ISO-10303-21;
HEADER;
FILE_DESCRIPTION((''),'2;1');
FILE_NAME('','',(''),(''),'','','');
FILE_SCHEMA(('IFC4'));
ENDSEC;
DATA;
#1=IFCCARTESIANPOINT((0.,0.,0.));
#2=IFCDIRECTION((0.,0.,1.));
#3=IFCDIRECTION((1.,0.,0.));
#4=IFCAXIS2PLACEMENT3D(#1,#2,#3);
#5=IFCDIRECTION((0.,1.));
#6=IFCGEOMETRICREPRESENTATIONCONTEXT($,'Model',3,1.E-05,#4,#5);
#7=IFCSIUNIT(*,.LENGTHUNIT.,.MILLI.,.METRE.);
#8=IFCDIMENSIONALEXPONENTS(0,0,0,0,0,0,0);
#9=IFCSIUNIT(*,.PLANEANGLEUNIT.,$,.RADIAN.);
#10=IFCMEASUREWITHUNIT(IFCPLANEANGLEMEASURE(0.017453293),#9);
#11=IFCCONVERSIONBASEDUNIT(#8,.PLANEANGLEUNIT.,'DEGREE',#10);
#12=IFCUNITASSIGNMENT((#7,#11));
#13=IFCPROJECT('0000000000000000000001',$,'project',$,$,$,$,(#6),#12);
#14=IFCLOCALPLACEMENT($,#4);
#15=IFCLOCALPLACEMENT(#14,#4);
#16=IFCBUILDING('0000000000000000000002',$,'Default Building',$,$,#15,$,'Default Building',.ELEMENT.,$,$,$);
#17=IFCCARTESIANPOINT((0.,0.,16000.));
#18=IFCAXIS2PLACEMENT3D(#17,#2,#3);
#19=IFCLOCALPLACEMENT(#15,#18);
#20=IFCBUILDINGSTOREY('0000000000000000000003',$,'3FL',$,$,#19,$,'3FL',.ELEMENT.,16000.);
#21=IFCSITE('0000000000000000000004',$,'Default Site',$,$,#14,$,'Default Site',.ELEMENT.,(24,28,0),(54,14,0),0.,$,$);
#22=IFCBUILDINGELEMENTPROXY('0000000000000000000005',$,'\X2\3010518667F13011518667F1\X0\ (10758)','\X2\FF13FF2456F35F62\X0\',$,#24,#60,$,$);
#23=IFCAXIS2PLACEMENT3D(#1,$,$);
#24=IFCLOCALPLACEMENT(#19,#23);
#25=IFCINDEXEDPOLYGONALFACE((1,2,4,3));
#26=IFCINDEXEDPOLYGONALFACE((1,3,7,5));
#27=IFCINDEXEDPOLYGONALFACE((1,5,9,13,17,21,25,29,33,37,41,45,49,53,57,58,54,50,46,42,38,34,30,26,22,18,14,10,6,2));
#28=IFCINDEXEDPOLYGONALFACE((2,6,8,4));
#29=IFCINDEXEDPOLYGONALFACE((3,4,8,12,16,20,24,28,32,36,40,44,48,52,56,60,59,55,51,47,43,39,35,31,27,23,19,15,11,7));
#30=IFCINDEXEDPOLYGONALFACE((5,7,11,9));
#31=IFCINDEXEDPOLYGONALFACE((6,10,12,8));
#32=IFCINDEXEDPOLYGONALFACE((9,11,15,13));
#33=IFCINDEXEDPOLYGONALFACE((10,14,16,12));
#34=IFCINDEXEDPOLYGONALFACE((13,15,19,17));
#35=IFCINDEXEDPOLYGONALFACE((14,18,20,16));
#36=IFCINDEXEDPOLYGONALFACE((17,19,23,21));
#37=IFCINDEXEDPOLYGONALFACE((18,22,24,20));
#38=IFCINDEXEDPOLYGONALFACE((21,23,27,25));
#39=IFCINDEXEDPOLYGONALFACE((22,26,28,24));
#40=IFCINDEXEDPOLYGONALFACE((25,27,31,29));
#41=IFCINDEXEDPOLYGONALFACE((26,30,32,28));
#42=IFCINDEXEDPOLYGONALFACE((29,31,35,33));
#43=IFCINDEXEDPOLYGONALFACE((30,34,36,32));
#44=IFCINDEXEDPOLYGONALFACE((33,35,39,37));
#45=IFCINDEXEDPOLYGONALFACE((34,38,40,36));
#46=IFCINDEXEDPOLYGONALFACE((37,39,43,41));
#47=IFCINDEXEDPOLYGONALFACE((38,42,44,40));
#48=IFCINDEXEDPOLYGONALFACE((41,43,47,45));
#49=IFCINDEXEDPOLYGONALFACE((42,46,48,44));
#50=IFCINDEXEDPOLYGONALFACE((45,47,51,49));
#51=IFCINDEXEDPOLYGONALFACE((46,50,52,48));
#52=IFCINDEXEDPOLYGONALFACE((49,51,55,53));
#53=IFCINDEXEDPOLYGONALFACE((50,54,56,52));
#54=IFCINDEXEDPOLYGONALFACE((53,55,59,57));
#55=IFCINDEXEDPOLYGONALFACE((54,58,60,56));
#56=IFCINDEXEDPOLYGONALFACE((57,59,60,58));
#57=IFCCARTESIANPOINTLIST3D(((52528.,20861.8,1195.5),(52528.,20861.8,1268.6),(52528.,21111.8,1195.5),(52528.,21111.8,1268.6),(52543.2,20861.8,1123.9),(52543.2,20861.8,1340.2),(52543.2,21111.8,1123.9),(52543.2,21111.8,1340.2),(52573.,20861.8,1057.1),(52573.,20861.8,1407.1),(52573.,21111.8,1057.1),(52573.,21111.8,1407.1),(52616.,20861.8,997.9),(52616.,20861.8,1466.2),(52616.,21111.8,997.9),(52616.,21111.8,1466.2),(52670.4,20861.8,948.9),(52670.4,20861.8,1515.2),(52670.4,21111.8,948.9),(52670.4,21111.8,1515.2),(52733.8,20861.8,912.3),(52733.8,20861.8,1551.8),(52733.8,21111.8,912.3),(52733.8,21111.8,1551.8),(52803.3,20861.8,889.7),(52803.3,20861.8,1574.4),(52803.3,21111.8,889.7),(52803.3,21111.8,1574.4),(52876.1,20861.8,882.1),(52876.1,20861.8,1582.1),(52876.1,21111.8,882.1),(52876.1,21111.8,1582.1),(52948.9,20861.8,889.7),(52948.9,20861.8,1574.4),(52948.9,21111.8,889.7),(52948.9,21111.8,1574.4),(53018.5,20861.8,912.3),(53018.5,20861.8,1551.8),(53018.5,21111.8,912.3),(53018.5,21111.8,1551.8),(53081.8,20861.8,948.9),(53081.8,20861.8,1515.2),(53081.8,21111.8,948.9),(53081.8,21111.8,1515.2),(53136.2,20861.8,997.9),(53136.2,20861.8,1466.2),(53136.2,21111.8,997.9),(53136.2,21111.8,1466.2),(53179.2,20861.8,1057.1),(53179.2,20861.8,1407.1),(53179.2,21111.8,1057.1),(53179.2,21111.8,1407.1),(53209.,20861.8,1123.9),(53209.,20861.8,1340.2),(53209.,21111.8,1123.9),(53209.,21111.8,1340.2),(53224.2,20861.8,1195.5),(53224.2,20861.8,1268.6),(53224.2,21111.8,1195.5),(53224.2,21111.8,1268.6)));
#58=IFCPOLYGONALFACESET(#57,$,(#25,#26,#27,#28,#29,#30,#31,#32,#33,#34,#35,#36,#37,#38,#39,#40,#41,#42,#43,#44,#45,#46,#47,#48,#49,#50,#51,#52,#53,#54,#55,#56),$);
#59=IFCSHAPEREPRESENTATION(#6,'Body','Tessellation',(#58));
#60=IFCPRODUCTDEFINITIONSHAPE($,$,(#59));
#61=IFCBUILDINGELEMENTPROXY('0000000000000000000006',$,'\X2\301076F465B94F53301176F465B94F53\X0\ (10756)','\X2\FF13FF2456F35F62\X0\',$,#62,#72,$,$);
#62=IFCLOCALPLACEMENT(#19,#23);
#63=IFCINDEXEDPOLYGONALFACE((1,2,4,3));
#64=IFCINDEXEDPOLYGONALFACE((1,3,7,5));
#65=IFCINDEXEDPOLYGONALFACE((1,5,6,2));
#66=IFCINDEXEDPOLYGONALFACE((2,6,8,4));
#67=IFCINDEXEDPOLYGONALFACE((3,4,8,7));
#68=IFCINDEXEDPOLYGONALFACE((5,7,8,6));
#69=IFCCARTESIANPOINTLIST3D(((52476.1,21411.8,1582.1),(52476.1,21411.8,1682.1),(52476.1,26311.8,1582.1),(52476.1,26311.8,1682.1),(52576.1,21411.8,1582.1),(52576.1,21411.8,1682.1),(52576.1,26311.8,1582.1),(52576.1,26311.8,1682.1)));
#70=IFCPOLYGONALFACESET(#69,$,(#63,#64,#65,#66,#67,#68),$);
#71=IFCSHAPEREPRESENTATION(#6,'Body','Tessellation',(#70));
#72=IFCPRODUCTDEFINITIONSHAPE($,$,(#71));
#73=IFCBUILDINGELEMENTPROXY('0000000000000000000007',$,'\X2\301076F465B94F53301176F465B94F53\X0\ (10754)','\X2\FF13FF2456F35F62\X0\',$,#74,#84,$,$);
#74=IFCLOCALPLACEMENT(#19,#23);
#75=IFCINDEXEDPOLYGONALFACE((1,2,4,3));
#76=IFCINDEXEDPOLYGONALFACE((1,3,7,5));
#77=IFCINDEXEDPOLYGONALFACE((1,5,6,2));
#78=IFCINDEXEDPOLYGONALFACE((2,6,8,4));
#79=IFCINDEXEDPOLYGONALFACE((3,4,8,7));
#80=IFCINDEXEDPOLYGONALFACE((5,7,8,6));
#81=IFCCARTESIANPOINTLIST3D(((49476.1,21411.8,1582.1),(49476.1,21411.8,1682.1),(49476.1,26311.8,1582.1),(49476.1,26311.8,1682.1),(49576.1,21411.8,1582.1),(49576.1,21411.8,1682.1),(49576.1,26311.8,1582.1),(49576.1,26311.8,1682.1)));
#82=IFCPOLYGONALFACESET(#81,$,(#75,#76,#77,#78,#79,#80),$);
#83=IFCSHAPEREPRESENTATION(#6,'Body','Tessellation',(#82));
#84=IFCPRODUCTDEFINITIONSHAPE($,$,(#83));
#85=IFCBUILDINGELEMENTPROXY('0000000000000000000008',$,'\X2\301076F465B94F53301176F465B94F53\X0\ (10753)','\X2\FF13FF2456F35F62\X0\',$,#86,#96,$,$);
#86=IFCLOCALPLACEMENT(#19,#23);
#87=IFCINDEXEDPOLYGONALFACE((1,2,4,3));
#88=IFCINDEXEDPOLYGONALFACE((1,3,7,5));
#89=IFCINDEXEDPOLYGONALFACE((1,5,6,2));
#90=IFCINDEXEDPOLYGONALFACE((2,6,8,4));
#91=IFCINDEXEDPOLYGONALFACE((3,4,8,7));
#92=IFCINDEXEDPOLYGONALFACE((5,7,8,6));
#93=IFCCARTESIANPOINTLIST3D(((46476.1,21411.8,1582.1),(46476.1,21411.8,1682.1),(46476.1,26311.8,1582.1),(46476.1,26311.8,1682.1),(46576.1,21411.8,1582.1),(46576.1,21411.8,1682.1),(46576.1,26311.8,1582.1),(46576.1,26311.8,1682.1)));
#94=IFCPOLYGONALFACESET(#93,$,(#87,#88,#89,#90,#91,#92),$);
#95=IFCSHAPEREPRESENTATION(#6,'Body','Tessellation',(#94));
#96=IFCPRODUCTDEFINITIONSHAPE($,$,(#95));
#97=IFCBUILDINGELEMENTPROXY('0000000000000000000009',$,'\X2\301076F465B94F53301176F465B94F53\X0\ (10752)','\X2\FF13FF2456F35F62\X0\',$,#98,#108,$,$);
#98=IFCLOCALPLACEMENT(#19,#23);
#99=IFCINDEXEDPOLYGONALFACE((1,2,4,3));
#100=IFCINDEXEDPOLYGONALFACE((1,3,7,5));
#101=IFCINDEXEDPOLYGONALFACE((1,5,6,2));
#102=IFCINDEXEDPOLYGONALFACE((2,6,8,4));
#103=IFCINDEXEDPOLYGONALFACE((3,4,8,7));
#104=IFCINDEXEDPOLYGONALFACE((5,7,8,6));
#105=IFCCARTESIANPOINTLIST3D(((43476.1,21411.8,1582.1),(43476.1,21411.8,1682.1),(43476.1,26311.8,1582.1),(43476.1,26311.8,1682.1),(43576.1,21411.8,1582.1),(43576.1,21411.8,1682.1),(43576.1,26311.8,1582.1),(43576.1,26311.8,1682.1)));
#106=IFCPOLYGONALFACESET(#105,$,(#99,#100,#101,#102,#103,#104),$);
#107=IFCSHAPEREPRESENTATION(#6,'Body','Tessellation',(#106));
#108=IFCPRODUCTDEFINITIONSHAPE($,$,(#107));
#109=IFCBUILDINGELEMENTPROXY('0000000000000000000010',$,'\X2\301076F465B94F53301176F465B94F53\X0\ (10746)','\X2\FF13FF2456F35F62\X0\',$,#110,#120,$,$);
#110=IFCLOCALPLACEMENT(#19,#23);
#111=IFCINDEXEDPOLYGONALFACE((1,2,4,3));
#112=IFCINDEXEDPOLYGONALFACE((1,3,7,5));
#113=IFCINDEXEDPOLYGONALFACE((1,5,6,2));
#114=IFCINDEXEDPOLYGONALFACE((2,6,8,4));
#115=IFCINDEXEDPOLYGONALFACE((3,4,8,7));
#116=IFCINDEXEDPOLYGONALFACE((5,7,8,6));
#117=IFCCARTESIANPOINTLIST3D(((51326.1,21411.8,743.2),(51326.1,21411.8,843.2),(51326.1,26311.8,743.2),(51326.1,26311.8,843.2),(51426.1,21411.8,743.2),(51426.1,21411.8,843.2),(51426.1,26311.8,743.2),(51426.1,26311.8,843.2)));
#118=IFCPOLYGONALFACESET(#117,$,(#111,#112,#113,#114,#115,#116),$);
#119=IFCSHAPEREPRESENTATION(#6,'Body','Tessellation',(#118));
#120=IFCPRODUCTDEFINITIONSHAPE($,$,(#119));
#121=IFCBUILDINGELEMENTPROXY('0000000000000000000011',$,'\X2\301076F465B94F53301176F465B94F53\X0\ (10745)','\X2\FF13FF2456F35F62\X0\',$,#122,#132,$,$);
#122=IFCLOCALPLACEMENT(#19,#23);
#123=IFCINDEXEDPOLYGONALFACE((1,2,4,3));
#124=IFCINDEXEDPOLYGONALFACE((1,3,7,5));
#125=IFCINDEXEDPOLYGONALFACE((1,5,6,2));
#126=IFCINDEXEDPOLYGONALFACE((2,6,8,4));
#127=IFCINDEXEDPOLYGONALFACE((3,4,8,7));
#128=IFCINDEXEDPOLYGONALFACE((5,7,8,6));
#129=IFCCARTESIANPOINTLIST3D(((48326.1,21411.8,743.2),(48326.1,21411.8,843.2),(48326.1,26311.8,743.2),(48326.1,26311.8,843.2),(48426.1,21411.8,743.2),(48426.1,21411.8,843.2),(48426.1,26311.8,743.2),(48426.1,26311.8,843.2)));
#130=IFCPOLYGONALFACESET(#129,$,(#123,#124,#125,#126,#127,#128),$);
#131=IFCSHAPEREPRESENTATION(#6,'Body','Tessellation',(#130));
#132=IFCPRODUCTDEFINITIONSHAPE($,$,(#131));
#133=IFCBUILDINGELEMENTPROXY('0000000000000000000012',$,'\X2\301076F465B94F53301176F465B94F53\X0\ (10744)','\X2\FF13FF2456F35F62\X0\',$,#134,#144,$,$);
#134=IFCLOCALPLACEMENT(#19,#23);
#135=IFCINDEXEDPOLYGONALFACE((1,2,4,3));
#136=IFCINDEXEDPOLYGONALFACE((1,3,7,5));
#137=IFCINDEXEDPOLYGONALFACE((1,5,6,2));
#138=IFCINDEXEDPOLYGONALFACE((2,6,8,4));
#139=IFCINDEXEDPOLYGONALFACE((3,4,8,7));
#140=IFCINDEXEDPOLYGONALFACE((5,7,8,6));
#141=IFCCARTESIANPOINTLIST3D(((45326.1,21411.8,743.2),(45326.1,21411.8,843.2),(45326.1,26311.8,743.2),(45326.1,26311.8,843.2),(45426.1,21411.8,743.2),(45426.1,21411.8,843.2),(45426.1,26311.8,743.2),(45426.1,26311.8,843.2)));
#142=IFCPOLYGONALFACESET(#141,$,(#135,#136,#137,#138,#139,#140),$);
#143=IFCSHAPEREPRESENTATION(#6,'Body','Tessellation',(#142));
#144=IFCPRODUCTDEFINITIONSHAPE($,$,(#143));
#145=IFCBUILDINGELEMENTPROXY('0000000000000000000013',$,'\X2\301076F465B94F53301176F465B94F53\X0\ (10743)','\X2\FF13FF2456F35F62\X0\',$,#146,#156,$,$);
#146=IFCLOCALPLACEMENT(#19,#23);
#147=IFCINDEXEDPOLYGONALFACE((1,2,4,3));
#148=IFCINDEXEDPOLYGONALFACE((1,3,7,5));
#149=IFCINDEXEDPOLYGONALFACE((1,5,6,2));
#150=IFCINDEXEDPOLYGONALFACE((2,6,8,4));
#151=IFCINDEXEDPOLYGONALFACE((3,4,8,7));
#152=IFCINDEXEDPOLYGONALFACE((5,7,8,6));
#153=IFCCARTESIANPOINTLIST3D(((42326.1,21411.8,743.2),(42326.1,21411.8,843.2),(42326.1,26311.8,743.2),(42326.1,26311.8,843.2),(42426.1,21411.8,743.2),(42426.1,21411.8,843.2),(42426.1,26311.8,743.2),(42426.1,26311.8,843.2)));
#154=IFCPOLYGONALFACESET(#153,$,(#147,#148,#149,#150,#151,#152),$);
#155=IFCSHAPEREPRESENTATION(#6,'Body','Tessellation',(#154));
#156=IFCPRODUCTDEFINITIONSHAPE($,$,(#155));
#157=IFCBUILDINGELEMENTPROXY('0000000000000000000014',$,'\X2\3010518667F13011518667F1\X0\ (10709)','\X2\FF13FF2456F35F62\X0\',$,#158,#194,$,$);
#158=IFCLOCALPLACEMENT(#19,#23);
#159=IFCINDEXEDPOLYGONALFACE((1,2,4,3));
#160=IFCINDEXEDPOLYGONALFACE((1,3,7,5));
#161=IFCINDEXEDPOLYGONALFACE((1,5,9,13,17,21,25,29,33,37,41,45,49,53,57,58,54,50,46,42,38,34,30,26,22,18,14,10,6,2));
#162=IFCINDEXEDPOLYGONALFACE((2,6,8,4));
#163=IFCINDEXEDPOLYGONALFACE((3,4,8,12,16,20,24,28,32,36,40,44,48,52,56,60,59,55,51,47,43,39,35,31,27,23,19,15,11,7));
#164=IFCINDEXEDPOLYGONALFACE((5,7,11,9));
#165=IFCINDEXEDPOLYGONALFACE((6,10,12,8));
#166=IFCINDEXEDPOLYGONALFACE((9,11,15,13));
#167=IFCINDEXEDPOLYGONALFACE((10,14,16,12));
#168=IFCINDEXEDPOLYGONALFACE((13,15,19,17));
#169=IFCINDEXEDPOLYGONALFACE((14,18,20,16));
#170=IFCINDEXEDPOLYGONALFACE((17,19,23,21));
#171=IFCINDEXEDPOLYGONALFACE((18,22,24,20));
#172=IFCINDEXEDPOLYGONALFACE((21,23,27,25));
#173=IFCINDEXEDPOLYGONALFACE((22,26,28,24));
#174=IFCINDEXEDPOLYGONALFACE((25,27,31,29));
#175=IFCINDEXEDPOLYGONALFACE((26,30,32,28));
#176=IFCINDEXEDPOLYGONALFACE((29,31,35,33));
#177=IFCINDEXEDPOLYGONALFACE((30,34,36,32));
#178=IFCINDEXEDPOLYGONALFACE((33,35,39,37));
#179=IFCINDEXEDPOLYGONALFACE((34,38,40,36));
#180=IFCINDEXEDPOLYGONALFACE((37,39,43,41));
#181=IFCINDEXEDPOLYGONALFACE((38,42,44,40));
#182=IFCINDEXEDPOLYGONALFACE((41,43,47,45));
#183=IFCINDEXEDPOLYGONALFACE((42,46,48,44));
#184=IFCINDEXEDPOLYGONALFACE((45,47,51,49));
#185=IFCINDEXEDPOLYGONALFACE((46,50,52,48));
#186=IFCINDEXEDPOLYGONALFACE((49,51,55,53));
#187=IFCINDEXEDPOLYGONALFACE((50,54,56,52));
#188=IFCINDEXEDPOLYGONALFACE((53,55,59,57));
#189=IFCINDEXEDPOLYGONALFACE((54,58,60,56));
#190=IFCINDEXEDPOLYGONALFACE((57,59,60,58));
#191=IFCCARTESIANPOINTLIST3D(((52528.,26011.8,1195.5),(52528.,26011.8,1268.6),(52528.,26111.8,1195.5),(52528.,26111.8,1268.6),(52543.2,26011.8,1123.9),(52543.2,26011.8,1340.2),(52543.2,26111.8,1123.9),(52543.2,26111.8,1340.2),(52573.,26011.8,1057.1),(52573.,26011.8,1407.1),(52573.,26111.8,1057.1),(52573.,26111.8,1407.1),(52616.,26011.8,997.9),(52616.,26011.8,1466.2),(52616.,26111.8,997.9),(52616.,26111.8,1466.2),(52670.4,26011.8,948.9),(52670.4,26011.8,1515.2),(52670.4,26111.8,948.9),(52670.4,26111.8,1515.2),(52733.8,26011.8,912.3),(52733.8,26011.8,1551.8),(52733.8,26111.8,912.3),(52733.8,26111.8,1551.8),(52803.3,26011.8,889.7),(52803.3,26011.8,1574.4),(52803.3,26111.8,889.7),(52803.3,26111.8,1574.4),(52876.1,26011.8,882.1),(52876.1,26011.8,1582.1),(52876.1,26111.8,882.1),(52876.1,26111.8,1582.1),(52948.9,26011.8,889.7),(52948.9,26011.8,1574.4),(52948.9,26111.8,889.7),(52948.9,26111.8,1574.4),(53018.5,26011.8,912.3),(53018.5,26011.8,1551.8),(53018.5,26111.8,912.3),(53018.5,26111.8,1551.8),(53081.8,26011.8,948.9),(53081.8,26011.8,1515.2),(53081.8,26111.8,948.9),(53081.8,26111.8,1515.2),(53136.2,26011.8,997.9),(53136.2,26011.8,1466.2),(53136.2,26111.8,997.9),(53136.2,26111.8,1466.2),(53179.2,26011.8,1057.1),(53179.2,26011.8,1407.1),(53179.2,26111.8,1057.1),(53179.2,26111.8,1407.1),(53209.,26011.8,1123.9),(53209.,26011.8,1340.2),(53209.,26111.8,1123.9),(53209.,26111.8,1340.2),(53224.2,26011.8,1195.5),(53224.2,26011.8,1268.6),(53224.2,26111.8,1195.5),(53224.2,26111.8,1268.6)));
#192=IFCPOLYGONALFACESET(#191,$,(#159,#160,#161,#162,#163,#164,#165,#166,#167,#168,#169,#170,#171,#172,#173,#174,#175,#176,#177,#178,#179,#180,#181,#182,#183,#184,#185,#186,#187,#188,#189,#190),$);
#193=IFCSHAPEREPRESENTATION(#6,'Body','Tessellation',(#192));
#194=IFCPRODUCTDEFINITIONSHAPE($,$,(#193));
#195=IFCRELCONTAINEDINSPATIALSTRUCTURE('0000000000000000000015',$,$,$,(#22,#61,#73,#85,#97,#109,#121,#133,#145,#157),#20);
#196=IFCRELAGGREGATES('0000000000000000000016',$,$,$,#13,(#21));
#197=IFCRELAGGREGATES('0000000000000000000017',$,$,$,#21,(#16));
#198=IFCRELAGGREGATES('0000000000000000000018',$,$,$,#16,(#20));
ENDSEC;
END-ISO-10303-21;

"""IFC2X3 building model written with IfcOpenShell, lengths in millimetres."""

from ifc_helpers import new_model, entity, si_unit, converted_unit, direction, frame, origin_with_axes, origin_2d_with_axis, place, context, project, spatial, rectangle, circle, extrude, source, transform, mapped, element, save


model = new_model("IFC2X3")

# Units and contexts
model_context = context("Model", 3, precision=1e-05, world=origin_with_axes(), true_north=direction((0.0, 1.0)))
ifc_project = project(units=[si_unit("LENGTHUNIT", "METRE", prefix="MILLI"), converted_unit("PLANEANGLEUNIT", "DEGREE", entity("IfcPlaneAngleMeasure", 0.017453293), si_unit("PLANEANGLEUNIT", "RADIAN"), dimensions=[0, 0, 0, 0, 0, 0, 0])], contexts=[model_context])

# Site, building, storey
site_placement = place(None, origin_with_axes())
site = spatial("IfcSite", under=ifc_project, at=site_placement, Name="Default Site", LongName="Default Site", CompositionType="ELEMENT", RefLatitude=(24, 28, 0), RefLongitude=(54, 14, 0), RefElevation=0.0)
building_placement = place(site_placement, origin_with_axes())
building = spatial("IfcBuilding", under=site, at=building_placement, Name="Default Building", LongName="Default Building", CompositionType="ELEMENT")
storey_placement = place(building_placement, frame((0.0, 0.0, 16000.0), z_axis=(0.0, 0.0, 1.0), x_axis=(1.0, 0.0, 0.0)))
storey = spatial("IfcBuildingStorey", under=building, at=storey_placement, Name="3FL", LongName="3FL", CompositionType="ELEMENT", Elevation=16000.0)

# Building element proxies
shared_shape_1 = source(origin_with_axes(), model_context, "Body", "SweptSolid", [
    extrude(circle(Radius=350.0, at=origin_2d_with_axis()), frame((0.0, 0.0, 0.0), z_axis=(0.0, 0.0, 1.0), x_axis=(1.0, 0.0, 0.0)), (0.0, 0.0, 1.0), 250.0),
])
proxy_1_placement = place(storey_placement, frame((52876.1, 20861.8, 1232.1), z_axis=(0.0, 1.0, 0.0), x_axis=(0.0, 0.0, -1.0)))
element("IfcBuildingElementProxy", 1, at=proxy_1_placement, inside=storey, Name="【円柱】円柱 (10758)", Description="３Ｄ図形", context=model_context, shape_type="MappedRepresentation", body=[
    mapped(shared_shape_1, transform((0.0, 0.0, 0.0))),
])
shared_shape_2 = source(origin_with_axes(), model_context, "Body", "SweptSolid", [
    extrude(rectangle(XDim=100.0, YDim=4900.0, at=origin_2d_with_axis()), origin_with_axes(), (0.0, 0.0, 1.0), 100.0),
])
proxy_2_placement = place(storey_placement, frame((52526.1, 23861.8, 1582.1), z_axis=(0.0, 0.0, 1.0), x_axis=(1.0, 0.0, 0.0)))
element("IfcBuildingElementProxy", 2, at=proxy_2_placement, inside=storey, Name="【直方体】直方体 (10756)", Description="３Ｄ図形", context=model_context, shape_type="MappedRepresentation", body=[
    mapped(shared_shape_2, transform((0.0, 0.0, 0.0))),
])
shared_shape_3 = source(origin_with_axes(), model_context, "Body", "SweptSolid", [
    extrude(rectangle(XDim=100.0, YDim=4900.0, at=origin_2d_with_axis()), origin_with_axes(), (0.0, 0.0, 1.0), 100.0),
])
proxy_3_placement = place(storey_placement, frame((49526.1, 23861.8, 1582.1), z_axis=(0.0, 0.0, 1.0), x_axis=(1.0, 0.0, 0.0)))
element("IfcBuildingElementProxy", 3, at=proxy_3_placement, inside=storey, Name="【直方体】直方体 (10754)", Description="３Ｄ図形", context=model_context, shape_type="MappedRepresentation", body=[
    mapped(shared_shape_3, transform((0.0, 0.0, 0.0))),
])
shared_shape_4 = source(origin_with_axes(), model_context, "Body", "SweptSolid", [
    extrude(rectangle(XDim=100.0, YDim=4900.0, at=origin_2d_with_axis()), origin_with_axes(), (0.0, 0.0, 1.0), 100.0),
])
proxy_4_placement = place(storey_placement, frame((46526.1, 23861.8, 1582.1), z_axis=(0.0, 0.0, 1.0), x_axis=(1.0, 0.0, 0.0)))
element("IfcBuildingElementProxy", 4, at=proxy_4_placement, inside=storey, Name="【直方体】直方体 (10753)", Description="３Ｄ図形", context=model_context, shape_type="MappedRepresentation", body=[
    mapped(shared_shape_4, transform((0.0, 0.0, 0.0))),
])
shared_shape_5 = source(origin_with_axes(), model_context, "Body", "SweptSolid", [
    extrude(rectangle(XDim=100.0, YDim=4900.0, at=origin_2d_with_axis()), origin_with_axes(), (0.0, 0.0, 1.0), 100.0),
])
proxy_5_placement = place(storey_placement, frame((43526.1, 23861.8, 1582.1), z_axis=(0.0, 0.0, 1.0), x_axis=(1.0, 0.0, 0.0)))
element("IfcBuildingElementProxy", 5, at=proxy_5_placement, inside=storey, Name="【直方体】直方体 (10752)", Description="３Ｄ図形", context=model_context, shape_type="MappedRepresentation", body=[
    mapped(shared_shape_5, transform((0.0, 0.0, 0.0))),
])
shared_shape_6 = source(origin_with_axes(), model_context, "Body", "SweptSolid", [
    extrude(rectangle(XDim=100.0, YDim=4900.0, at=origin_2d_with_axis()), origin_with_axes(), (0.0, 0.0, 1.0), 100.0),
])
proxy_6_placement = place(storey_placement, frame((51376.1, 23861.8, 743.2), z_axis=(0.0, 0.0, 1.0), x_axis=(1.0, 0.0, 0.0)))
element("IfcBuildingElementProxy", 6, at=proxy_6_placement, inside=storey, Name="【直方体】直方体 (10746)", Description="３Ｄ図形", context=model_context, shape_type="MappedRepresentation", body=[
    mapped(shared_shape_6, transform((0.0, 0.0, 0.0))),
])
shared_shape_7 = source(origin_with_axes(), model_context, "Body", "SweptSolid", [
    extrude(rectangle(XDim=100.0, YDim=4900.0, at=origin_2d_with_axis()), origin_with_axes(), (0.0, 0.0, 1.0), 100.0),
])
proxy_7_placement = place(storey_placement, frame((48376.1, 23861.8, 743.2), z_axis=(0.0, 0.0, 1.0), x_axis=(1.0, 0.0, 0.0)))
element("IfcBuildingElementProxy", 7, at=proxy_7_placement, inside=storey, Name="【直方体】直方体 (10745)", Description="３Ｄ図形", context=model_context, shape_type="MappedRepresentation", body=[
    mapped(shared_shape_7, transform((0.0, 0.0, 0.0))),
])
shared_shape_8 = source(origin_with_axes(), model_context, "Body", "SweptSolid", [
    extrude(rectangle(XDim=100.0, YDim=4900.0, at=origin_2d_with_axis()), origin_with_axes(), (0.0, 0.0, 1.0), 100.0),
])
proxy_8_placement = place(storey_placement, frame((45376.1, 23861.8, 743.2), z_axis=(0.0, 0.0, 1.0), x_axis=(1.0, 0.0, 0.0)))
element("IfcBuildingElementProxy", 8, at=proxy_8_placement, inside=storey, Name="【直方体】直方体 (10744)", Description="３Ｄ図形", context=model_context, shape_type="MappedRepresentation", body=[
    mapped(shared_shape_8, transform((0.0, 0.0, 0.0))),
])
shared_shape_9 = source(origin_with_axes(), model_context, "Body", "SweptSolid", [
    extrude(rectangle(XDim=100.0, YDim=4900.0, at=origin_2d_with_axis()), origin_with_axes(), (0.0, 0.0, 1.0), 100.0),
])
proxy_9_placement = place(storey_placement, frame((42376.1, 23861.8, 743.2), z_axis=(0.0, 0.0, 1.0), x_axis=(1.0, 0.0, 0.0)))
element("IfcBuildingElementProxy", 9, at=proxy_9_placement, inside=storey, Name="【直方体】直方体 (10743)", Description="３Ｄ図形", context=model_context, shape_type="MappedRepresentation", body=[
    mapped(shared_shape_9, transform((0.0, 0.0, 0.0))),
])
shared_shape_10 = source(origin_with_axes(), model_context, "Body", "SweptSolid", [
    extrude(circle(Radius=350.0, at=origin_2d_with_axis()), frame((0.0, 0.0, 0.0), z_axis=(0.0, 0.0, 1.0), x_axis=(1.0, 0.0, 0.0)), (0.0, 0.0, 1.0), 100.0),
])
proxy_10_placement = place(storey_placement, frame((52876.1, 26011.8, 1232.1), z_axis=(0.0, 1.0, 0.0), x_axis=(0.0, 0.0, -1.0)))
element("IfcBuildingElementProxy", 10, at=proxy_10_placement, inside=storey, Name="【円柱】円柱 (10709)", Description="３Ｄ図形", context=model_context, shape_type="MappedRepresentation", body=[
    mapped(shared_shape_10, transform((0.0, 0.0, 0.0))),
])

save(model, "model.ifc")
